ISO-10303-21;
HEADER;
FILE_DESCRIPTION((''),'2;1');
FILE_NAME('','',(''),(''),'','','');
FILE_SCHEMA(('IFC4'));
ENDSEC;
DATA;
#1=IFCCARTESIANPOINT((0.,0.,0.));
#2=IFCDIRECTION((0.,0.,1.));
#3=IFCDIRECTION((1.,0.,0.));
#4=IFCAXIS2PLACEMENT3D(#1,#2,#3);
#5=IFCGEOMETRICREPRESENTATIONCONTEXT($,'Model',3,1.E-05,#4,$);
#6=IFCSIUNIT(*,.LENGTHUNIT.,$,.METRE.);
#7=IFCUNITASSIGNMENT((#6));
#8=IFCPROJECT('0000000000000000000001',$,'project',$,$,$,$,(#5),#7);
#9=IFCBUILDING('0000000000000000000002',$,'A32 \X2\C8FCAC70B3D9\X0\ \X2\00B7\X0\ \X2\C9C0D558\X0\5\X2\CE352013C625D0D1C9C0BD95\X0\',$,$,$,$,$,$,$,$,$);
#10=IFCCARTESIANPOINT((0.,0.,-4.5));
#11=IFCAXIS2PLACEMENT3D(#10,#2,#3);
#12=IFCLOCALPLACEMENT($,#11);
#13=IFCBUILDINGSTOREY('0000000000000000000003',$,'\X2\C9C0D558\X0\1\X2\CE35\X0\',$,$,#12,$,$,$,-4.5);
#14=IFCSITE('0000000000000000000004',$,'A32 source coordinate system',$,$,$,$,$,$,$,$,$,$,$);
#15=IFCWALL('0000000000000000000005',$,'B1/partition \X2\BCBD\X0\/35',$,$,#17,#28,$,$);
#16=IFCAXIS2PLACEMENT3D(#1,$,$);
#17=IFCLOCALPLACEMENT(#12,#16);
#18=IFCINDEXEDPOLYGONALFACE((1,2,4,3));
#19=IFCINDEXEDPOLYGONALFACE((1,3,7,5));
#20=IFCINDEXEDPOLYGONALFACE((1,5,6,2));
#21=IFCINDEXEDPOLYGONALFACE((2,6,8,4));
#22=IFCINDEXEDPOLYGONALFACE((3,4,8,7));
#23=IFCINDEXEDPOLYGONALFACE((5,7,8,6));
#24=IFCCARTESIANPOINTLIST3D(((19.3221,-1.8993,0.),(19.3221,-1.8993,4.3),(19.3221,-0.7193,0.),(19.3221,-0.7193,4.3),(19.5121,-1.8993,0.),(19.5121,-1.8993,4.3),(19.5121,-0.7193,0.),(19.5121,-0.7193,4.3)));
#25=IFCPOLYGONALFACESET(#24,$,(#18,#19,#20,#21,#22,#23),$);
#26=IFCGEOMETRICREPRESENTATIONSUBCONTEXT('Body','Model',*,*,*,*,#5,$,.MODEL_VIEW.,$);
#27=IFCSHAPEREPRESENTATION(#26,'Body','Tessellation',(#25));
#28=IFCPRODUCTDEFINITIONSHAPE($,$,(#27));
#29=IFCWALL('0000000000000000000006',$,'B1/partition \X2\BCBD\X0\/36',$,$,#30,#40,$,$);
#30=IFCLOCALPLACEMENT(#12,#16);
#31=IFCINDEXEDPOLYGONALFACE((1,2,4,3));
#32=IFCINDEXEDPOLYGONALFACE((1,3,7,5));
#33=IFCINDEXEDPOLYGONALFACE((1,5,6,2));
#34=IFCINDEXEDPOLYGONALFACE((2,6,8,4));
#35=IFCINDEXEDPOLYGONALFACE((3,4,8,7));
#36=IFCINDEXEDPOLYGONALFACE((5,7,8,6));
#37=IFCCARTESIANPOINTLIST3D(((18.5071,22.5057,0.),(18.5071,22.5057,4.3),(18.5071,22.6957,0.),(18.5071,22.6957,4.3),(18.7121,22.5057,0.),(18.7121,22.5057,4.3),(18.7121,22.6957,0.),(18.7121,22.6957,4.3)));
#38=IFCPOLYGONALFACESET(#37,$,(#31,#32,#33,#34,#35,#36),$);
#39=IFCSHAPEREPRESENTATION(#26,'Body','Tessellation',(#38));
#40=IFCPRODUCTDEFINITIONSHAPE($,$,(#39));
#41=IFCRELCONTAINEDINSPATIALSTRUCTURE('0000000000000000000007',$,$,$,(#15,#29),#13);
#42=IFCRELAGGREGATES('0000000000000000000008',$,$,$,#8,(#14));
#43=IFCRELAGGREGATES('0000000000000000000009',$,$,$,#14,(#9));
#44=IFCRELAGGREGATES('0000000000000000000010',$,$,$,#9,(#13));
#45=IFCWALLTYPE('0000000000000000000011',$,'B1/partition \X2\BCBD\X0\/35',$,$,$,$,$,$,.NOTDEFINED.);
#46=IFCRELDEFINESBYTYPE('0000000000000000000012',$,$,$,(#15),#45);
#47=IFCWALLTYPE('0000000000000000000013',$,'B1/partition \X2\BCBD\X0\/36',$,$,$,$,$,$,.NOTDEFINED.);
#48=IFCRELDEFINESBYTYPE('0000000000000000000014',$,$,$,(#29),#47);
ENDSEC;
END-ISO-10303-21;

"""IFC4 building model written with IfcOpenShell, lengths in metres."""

from ifc_helpers import new_model, si_unit, frame, origin, origin_with_axes, place, context, subcontext, project, spatial, polyline, outline, extrude, source, transform, mapped, type_object, type_shapes, element, save


model = new_model("IFC4")

# Units and contexts
model_context = context("Model", 3, precision=1e-05, world=origin_with_axes())
body_context = subcontext(model_context, "Body", "Model", "MODEL_VIEW")
ifc_project = project(units=[si_unit("LENGTHUNIT", "METRE")], contexts=[model_context])

# Site, building, storey
site = spatial("IfcSite", under=ifc_project, Name="A32 source coordinate system")
building = spatial("IfcBuilding", under=site, Name="A32 주거동 · 지하5층–옥탑지붕")
storey_placement = place(None, frame((0.0, 0.0, -4.5), z_axis=(0.0, 0.0, 1.0), x_axis=(1.0, 0.0, 0.0)))
storey = spatial("IfcBuildingStorey", under=building, at=storey_placement, Name="지하1층", Elevation=-4.5)

# Walls
wall_type_1 = type_object("IfcWallType", Name="B1/partition 벽/35", PredefinedType="NOTDEFINED")
shared_shape_1 = source(origin(), body_context, "Body", "SweptSolid", [
    extrude(outline(polyline([(19.5121, -0.7193), (19.5121, -1.8993), (19.3221, -1.8993), (19.3221, -0.7193), (19.5121, -0.7193)])), origin(), (0.0, 0.0, 1.0), 4.3),
])
type_shapes(wall_type_1, [shared_shape_1])
wall_1_placement = place(storey_placement, origin_with_axes())
element("IfcWall", 1, at=wall_1_placement, inside=storey, type_object=wall_type_1, Name="B1/partition 벽/35", context=body_context, shape_type="MappedRepresentation", body=[
    mapped(shared_shape_1, transform((0.0, 0.0, 0.0), scale=1.0)),
])
wall_type_2 = type_object("IfcWallType", Name="B1/partition 벽/36", PredefinedType="NOTDEFINED")
shared_shape_2 = source(origin(), body_context, "Body", "SweptSolid", [
    extrude(outline(polyline([(18.7121, 22.6957), (18.7121, 22.5057), (18.5071, 22.5057), (18.5071, 22.6957), (18.7121, 22.6957)])), origin(), (0.0, 0.0, 1.0), 4.3),
])
type_shapes(wall_type_2, [shared_shape_2])
wall_2_placement = place(storey_placement, origin_with_axes())
element("IfcWall", 2, at=wall_2_placement, inside=storey, type_object=wall_type_2, Name="B1/partition 벽/36", context=body_context, shape_type="MappedRepresentation", body=[
    mapped(shared_shape_2, transform((0.0, 0.0, 0.0), scale=1.0)),
])

save(model, "model.ifc")
